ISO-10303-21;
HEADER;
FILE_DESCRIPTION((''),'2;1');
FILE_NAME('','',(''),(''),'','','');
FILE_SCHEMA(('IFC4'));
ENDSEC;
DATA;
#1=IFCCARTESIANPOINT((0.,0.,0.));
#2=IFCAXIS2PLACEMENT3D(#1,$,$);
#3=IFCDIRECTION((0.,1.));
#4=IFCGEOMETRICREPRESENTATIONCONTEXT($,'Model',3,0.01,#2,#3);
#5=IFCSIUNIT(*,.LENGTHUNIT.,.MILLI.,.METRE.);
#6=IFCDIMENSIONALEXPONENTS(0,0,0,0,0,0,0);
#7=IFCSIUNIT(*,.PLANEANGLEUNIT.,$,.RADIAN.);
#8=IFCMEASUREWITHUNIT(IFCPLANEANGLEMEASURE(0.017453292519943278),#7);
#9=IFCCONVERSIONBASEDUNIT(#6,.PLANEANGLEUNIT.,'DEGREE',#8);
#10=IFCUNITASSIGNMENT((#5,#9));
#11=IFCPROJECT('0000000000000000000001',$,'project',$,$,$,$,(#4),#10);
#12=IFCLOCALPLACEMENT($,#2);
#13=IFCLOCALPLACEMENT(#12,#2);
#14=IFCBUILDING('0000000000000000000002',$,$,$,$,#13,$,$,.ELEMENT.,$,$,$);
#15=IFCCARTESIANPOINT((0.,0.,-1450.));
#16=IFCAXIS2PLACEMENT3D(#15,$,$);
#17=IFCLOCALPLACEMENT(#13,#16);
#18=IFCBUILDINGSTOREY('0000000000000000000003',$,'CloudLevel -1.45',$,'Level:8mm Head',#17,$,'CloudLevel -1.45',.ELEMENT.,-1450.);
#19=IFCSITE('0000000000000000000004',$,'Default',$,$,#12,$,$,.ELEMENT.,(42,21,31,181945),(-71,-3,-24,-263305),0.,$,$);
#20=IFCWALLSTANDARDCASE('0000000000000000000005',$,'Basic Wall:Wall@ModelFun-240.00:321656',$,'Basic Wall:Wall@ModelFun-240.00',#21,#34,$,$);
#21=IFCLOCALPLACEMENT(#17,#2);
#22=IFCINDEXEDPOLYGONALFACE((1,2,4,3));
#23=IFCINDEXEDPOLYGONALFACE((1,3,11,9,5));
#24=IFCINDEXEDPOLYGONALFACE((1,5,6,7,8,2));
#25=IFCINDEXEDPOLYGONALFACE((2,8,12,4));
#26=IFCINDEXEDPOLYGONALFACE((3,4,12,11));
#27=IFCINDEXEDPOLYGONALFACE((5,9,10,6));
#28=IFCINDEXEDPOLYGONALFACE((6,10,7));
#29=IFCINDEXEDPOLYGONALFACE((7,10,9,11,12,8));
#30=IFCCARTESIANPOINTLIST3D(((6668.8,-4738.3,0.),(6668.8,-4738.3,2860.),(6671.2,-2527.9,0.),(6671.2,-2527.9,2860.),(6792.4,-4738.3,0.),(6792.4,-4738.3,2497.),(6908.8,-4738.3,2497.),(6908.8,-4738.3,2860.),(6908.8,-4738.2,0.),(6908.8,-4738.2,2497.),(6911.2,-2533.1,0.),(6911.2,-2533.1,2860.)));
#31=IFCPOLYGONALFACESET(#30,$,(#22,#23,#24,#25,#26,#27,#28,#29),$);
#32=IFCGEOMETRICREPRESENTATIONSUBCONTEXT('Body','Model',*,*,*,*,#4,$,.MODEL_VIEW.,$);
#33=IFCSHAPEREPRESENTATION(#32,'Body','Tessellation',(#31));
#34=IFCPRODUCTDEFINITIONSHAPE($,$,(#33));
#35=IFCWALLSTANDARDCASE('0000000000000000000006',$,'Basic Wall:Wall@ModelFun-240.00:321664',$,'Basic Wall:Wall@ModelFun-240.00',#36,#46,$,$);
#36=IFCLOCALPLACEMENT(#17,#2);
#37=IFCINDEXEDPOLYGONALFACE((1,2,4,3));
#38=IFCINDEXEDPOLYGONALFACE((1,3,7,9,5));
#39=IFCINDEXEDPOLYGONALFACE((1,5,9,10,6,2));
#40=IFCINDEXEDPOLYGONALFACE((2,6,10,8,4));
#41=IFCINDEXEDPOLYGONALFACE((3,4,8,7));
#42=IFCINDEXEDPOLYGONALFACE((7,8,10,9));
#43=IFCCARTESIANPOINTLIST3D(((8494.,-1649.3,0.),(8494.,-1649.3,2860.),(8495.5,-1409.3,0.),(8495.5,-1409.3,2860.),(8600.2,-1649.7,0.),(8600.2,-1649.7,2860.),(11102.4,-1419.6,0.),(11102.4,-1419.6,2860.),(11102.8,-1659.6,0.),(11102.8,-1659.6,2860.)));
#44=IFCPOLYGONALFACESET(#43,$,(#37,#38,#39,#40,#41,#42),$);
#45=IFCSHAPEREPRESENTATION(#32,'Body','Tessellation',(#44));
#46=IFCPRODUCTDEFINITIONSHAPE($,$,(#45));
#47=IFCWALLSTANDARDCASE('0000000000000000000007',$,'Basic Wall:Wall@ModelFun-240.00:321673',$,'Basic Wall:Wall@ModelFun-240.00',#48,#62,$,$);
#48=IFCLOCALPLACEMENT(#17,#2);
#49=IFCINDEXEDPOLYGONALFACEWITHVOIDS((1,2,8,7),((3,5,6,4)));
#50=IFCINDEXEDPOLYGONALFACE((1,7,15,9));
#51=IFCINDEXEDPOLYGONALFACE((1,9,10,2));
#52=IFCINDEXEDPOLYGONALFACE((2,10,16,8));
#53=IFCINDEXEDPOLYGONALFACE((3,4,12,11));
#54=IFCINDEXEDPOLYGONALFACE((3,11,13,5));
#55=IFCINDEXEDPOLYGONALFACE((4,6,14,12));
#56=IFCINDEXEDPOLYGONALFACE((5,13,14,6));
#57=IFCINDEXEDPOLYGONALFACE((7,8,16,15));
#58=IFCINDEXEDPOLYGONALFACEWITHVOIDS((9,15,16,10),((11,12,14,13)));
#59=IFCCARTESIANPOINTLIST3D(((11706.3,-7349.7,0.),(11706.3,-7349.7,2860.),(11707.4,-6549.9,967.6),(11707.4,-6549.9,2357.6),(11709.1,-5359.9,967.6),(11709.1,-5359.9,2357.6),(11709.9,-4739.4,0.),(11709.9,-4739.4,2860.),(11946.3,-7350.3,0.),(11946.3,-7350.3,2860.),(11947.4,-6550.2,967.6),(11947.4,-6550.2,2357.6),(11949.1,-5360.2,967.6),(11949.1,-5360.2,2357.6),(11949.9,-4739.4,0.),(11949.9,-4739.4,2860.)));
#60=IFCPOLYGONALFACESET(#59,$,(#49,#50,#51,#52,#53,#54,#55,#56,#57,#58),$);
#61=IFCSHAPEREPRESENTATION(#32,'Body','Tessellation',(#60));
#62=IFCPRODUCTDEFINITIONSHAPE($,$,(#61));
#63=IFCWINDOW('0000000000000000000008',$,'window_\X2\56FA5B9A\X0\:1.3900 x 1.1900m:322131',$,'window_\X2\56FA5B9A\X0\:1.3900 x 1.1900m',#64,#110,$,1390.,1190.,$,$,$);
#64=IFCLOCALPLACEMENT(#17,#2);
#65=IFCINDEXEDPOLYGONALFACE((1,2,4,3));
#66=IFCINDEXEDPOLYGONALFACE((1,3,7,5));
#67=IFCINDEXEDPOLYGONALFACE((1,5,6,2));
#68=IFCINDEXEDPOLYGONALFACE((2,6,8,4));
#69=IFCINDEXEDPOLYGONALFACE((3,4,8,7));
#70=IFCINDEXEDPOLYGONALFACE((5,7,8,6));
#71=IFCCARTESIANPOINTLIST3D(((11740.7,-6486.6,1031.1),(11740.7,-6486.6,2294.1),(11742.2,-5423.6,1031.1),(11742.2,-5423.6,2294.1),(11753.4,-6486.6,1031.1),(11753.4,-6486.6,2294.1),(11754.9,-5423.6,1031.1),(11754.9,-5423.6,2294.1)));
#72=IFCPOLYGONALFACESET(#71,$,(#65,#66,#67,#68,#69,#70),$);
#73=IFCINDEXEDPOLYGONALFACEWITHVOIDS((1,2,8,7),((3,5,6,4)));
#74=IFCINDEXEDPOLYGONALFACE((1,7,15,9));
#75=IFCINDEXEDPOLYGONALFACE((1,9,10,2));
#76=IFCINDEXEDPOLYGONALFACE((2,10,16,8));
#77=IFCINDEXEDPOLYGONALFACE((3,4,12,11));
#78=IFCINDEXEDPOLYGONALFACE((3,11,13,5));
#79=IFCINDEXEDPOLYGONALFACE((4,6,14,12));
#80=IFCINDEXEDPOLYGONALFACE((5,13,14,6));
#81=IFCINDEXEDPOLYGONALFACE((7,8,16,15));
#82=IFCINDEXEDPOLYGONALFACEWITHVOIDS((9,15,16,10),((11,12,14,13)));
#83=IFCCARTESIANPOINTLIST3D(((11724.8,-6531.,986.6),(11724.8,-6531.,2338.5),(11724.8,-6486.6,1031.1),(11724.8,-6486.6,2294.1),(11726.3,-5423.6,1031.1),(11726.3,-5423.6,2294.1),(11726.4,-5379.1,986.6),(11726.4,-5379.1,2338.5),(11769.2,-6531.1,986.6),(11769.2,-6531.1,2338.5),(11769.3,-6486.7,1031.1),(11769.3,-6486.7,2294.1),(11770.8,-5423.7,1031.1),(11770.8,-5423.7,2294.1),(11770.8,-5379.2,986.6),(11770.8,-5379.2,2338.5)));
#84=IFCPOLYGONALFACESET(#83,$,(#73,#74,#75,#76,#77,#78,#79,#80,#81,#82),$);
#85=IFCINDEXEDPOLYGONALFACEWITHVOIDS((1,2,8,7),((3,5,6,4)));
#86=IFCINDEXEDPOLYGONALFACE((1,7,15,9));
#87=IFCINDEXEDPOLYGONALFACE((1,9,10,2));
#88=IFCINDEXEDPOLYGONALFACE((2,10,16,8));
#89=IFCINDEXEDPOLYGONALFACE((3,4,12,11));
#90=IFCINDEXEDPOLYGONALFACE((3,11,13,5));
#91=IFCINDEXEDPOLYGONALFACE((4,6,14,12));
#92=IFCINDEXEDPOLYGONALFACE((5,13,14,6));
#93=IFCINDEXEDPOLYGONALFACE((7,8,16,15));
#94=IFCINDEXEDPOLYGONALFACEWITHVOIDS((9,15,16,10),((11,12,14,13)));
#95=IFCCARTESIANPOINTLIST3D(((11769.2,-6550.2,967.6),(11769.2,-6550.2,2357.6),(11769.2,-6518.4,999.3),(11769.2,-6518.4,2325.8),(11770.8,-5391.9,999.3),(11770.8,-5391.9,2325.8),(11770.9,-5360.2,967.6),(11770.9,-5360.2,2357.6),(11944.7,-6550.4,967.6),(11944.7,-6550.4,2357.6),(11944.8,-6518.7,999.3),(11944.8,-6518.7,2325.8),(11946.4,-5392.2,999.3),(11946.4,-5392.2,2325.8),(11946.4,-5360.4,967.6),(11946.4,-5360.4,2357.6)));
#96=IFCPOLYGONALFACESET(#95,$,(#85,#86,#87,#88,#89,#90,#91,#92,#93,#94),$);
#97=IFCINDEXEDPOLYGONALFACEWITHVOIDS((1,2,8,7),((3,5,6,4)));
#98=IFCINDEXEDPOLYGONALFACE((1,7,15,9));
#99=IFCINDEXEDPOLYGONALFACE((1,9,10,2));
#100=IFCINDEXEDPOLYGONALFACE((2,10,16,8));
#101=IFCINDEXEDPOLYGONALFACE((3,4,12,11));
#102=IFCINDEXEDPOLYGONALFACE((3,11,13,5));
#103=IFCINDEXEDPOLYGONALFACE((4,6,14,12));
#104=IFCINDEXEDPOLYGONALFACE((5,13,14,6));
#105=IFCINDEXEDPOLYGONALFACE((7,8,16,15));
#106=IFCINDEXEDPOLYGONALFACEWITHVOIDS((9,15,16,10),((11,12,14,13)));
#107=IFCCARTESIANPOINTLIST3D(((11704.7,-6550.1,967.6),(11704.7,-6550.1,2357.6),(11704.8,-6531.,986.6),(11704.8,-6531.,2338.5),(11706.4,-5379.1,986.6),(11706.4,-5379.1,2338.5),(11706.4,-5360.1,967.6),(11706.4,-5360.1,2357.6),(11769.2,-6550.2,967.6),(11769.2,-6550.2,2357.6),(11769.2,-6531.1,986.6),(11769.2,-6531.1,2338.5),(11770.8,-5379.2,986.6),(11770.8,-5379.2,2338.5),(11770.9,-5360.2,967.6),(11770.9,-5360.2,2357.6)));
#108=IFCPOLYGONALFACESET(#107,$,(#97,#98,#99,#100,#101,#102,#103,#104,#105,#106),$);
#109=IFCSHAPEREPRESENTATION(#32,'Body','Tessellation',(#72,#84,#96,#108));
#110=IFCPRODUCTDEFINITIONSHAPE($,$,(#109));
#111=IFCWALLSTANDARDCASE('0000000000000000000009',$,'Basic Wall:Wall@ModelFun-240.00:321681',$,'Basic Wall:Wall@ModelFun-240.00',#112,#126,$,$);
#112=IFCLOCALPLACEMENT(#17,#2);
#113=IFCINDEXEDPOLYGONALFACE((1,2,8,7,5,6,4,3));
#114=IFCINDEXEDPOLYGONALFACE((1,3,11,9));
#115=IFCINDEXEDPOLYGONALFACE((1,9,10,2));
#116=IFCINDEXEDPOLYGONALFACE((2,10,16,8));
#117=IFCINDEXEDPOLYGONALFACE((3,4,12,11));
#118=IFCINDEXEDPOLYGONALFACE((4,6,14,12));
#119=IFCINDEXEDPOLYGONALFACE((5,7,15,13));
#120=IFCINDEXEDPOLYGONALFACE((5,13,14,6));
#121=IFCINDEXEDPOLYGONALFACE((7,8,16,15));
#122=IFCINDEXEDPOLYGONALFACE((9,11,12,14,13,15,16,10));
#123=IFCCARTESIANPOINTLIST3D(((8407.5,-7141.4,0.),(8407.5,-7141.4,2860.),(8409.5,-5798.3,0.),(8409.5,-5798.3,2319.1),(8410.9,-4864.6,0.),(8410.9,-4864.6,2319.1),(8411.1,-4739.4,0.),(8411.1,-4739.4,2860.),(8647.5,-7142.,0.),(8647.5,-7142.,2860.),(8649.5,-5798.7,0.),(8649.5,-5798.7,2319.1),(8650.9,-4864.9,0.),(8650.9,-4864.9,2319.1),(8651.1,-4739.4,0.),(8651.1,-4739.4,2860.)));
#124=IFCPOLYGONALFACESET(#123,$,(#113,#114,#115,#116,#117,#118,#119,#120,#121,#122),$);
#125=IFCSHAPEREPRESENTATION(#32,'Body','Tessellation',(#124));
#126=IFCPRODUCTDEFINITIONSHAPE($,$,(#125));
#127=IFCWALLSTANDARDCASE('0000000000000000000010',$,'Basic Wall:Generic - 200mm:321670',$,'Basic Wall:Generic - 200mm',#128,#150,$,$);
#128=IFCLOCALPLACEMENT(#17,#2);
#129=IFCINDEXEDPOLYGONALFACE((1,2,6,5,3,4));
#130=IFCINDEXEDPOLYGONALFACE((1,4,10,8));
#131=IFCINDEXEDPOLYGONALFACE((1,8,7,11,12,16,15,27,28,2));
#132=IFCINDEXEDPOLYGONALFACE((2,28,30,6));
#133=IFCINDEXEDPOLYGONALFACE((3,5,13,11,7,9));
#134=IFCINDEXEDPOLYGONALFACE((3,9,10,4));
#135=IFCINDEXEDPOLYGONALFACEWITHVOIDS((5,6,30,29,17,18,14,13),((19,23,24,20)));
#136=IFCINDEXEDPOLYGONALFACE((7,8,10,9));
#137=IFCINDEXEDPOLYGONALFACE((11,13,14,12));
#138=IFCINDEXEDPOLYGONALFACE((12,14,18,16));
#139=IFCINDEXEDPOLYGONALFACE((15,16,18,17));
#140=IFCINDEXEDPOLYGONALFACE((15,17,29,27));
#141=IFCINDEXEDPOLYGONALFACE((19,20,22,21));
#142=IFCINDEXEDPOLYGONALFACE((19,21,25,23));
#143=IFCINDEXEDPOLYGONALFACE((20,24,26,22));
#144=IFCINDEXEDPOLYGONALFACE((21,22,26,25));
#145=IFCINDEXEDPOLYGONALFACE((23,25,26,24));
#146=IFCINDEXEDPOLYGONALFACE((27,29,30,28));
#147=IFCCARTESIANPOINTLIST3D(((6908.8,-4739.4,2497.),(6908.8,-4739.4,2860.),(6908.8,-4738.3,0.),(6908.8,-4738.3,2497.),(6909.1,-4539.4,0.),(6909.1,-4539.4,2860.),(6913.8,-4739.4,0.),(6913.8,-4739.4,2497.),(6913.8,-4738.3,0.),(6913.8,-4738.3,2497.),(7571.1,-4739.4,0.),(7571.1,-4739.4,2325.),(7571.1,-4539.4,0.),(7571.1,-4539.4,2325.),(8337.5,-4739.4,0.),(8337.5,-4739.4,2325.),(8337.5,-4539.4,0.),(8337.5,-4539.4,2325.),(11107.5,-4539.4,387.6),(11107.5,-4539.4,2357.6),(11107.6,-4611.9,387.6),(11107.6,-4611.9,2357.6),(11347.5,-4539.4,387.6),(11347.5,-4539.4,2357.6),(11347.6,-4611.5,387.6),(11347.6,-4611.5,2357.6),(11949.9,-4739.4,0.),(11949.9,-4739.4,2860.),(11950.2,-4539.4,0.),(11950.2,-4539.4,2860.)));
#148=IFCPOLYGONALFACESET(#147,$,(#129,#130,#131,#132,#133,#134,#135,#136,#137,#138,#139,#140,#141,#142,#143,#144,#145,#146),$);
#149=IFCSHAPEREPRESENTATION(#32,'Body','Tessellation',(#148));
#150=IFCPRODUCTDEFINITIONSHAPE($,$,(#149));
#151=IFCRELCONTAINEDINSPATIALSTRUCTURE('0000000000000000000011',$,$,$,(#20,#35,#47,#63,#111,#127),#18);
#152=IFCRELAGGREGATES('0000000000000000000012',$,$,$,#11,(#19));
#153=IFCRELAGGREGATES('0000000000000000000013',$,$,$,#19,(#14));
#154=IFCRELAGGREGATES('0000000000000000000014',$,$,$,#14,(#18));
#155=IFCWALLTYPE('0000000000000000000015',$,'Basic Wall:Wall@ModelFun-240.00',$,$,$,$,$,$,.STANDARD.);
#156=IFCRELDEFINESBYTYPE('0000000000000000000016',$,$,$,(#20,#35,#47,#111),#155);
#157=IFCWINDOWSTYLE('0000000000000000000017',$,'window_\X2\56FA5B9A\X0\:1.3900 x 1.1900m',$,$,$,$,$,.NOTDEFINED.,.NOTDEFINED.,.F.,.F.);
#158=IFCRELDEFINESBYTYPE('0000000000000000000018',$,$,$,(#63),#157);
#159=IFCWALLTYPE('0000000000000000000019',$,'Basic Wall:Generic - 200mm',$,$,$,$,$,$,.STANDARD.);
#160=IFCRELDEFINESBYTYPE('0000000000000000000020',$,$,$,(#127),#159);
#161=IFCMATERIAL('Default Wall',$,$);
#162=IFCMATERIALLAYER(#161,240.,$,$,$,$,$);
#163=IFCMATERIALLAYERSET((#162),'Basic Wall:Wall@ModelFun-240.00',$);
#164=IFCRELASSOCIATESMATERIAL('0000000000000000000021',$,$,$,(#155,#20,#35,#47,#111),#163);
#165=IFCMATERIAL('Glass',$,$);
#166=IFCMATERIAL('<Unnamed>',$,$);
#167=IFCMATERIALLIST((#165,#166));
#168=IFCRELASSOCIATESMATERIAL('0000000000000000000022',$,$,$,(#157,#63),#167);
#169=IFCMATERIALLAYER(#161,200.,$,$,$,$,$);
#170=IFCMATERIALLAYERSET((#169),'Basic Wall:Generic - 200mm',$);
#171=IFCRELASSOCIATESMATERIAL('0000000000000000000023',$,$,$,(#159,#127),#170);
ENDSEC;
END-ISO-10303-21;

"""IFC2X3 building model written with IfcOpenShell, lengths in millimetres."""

from ifc_helpers import new_model, entity, si_unit, converted_unit, direction, frame, frame_2d, origin, place, context, subcontext, project, spatial, polyline, rectangle, outline, extrude, source, transform, mapped, material, material_list, layer, layer_set, layer_usage, type_object, type_shapes, element, fill, save


model = new_model("IFC2X3")

# Units and contexts
model_context = context("Model", 3, precision=0.01, world=origin(), true_north=direction((0.0, 1.0)))
body_context = subcontext(model_context, "Body", "Model", "MODEL_VIEW")
ifc_project = project(units=[si_unit("LENGTHUNIT", "METRE", prefix="MILLI"), converted_unit("PLANEANGLEUNIT", "DEGREE", entity("IfcPlaneAngleMeasure", 0.017453292519943278), si_unit("PLANEANGLEUNIT", "RADIAN"), dimensions=[0, 0, 0, 0, 0, 0, 0])], contexts=[model_context])

# Site, building, storey
site_placement = place(None, origin())
site = spatial("IfcSite", under=ifc_project, at=site_placement, Name="Default", CompositionType="ELEMENT", RefLatitude=(42, 21, 31, 181945), RefLongitude=(-71, -3, -24, -263305), RefElevation=0.0)
building_placement = place(site_placement, origin())
building = spatial("IfcBuilding", under=site, at=building_placement, CompositionType="ELEMENT")
storey_placement = place(building_placement, frame((0.0, 0.0, -1450.0)))
storey = spatial("IfcBuildingStorey", under=building, at=storey_placement, Name="CloudLevel -1.45", ObjectType="Level:8mm Head", LongName="CloudLevel -1.45", CompositionType="ELEMENT", Elevation=-1450.0)

# Shared definitions
ifc_material_1 = material(Name="Default Wall")
ifc_layer_1 = layer(ifc_material_1, 240.0)
ifc_layer_set_1 = layer_set([ifc_layer_1], Name="Basic Wall:Wall@ModelFun-240.00")
ifc_layer_usage_1 = layer_usage(ifc_layer_set_1, "AXIS2", "NEGATIVE", 120.0)
wall_type_1 = type_object("IfcWallType", Name="Basic Wall:Wall@ModelFun-240.00", PredefinedType="STANDARD", material=ifc_layer_set_1)
ifc_material_2 = material(Name="Glass")
ifc_material_3 = material(Name="<Unnamed>")
ifc_material_list = material_list([ifc_material_2, ifc_material_3])

# Wall, opening
wall_1_placement = place(storey_placement, frame((6791.2, -2528.0, 0.0), z_axis=(0.0, 0.0, 1.0), x_axis=(-0.001074, -0.999999, 0.0)))
wall_1 = element("IfcWallStandardCase", 1, at=wall_1_placement, inside=storey, type_object=wall_type_1, material=ifc_layer_usage_1, Name="Basic Wall:Wall@ModelFun-240.00:321656", ObjectType="Basic Wall:Wall@ModelFun-240.00", context=body_context, shape_type="SweptSolid", body=[
    extrude(outline(polyline([(0.0, -120.0), (2210.4, -120.0), (2210.1, 120.0), (2011.2, 120.0), (5.0, 120.0), (0.0, -120.0)])), origin(), (0.0, 0.0, 1.0), 2860.0),
])
opening_1_placement = place(wall_1_placement, frame((0.0, 0.0, 0.0), z_axis=(0.0, 0.0, 1.0), x_axis=(0.999999, 0.001074, 0.0)))
element("IfcOpeningElement", 2, at=opening_1_placement, cuts=wall_1, ObjectType="Opening", context=body_context, shape_type="SweptSolid", body=[
    extrude(rectangle(XDim=2497.0, YDim=1048.4, at=frame_2d((0.0, 0.0), x_axis=(0.0, 1.0))), frame((2736.2, -1608.5, 1248.5), z_axis=(-0.001074, 0.999999, 0.0), x_axis=(-0.999999, -0.001074, 0.0)), (0.0, 0.0, 1.0), 3048.0),
])

# Wall
wall_2_placement = place(storey_placement, frame((11103.3, -1539.6, 0.0), z_axis=(0.0, 0.0, 1.0), x_axis=(-0.999992, 0.003928, 0.0)))
element("IfcWallStandardCase", 3, at=wall_2_placement, inside=storey, type_object=wall_type_1, material=ifc_layer_usage_1, Name="Basic Wall:Wall@ModelFun-240.00:321664", ObjectType="Basic Wall:Wall@ModelFun-240.00", context=body_context, shape_type="SweptSolid", body=[
    extrude(outline(polyline([(2608.3, -120.0), (2608.8, 120.0), (2502.6, 120.0), (0.0, 120.0), (1.3, -120.0), (2608.3, -120.0)])), origin(), (0.0, 0.0, 1.0), 2860.0),
])

# Wall, opening, window
wall_3_placement = place(storey_placement, frame((11829.9, -4739.3, 0.0), z_axis=(0.0, 0.0, 1.0), x_axis=(-0.001406, -0.999999, 0.0)))
wall_3 = element("IfcWallStandardCase", 4, at=wall_3_placement, inside=storey, type_object=wall_type_1, material=ifc_layer_usage_1, Name="Basic Wall:Wall@ModelFun-240.00:321673", ObjectType="Basic Wall:Wall@ModelFun-240.00", context=body_context, shape_type="SweptSolid", body=[
    extrude(outline(polyline([(2610.6, -120.0), (2610.6, -117.9), (2610.9, 120.0), (0.0, 120.0), (0.3, -120.0), (2410.6, -120.0), (2610.6, -120.0)])), origin(), (0.0, 0.0, 1.0), 2860.0),
])
opening_2_placement = place(wall_3_placement, frame((1810.8, 120.0, 967.6)))
opening_2 = element("IfcOpeningElement", 5, at=opening_2_placement, cuts=wall_3, ObjectType="Opening", context=body_context, shape_type="SweptSolid", body=[
    extrude(rectangle(XDim=1390.0, YDim=1190.0, at=frame_2d((695.0, 595.0), x_axis=(-1.0, 0.0))), frame((0.0, 0.0, 0.0), z_axis=(0.0, -1.0, 0.0), x_axis=(0.0, 0.0, 1.0)), (0.0, 0.0, 1.0), 240.0),
])
window_style_1 = type_object("IfcWindowStyle", Name="window_固定:1.3900 x 1.1900m", ConstructionType="NOTDEFINED", OperationType="NOTDEFINED", ParameterTakesPrecedence=False, Sizeable=False, material=ifc_material_list)
shared_shape_1 = source(origin(), body_context, "Body", "SweptSolid", [
    extrude(rectangle(XDim=1063.0, YDim=12.7, at=frame_2d((0.0, 0.0), x_axis=(1.0, 0.0))), frame((671.2, 197.8, 63.5)), (0.0, 0.0, 1.0), 1263.0),
    extrude(outline(polyline([(-575.9, -675.9), (575.9, -675.9), (575.9, 675.9), (-575.9, 675.9), (-575.9, -675.9)]), holes=[polyline([(-531.5, -631.5), (-531.5, 631.5), (531.5, 631.5), (531.5, -631.5), (-531.5, -631.5)])]), frame((671.2, 220.0, 695.0), z_axis=(0.0, -1.0, 0.0), x_axis=(-1.0, 0.0, 0.0)), (0.0, 0.0, 1.0), 44.4),
    extrude(outline(polyline([(-595.0, -695.0), (595.0, -695.0), (595.0, 695.0), (-595.0, 695.0), (-595.0, -695.0)]), holes=[polyline([(-563.2, -663.2), (-563.2, 663.2), (563.2, 663.2), (563.2, -663.2), (-563.2, -663.2)])]), frame((671.2, 175.5, 695.0), z_axis=(0.0, -1.0, 0.0), x_axis=(-1.0, 0.0, 0.0)), (0.0, 0.0, 1.0), 175.5),
    extrude(outline(polyline([(-695.0, -595.0), (695.0, -595.0), (695.0, 595.0), (-695.0, 595.0), (-695.0, -595.0)]), holes=[polyline([(-675.9, -575.9), (-675.9, 575.9), (675.9, 575.9), (675.9, -575.9), (-675.9, -575.9)])]), frame((671.2, 240.0, 695.0), z_axis=(0.0, -1.0, 0.0), x_axis=(0.0, 0.0, -1.0)), (0.0, 0.0, 1.0), 64.4),
])
type_shapes(window_style_1, [shared_shape_1])
window_1_placement = place(opening_2_placement, frame((76.4, -2.7, 0.0), z_axis=(0.0, 0.0, 1.0), x_axis=(-1.0, 0.0, 0.0)))
window_1 = element("IfcWindow", 6, at=window_1_placement, inside=storey, type_object=window_style_1, material=ifc_material_list, Name="window_固定:1.3900 x 1.1900m:322131", ObjectType="window_固定:1.3900 x 1.1900m", OverallHeight=1390.0, OverallWidth=1190.0, context=body_context, shape_type="MappedRepresentation", body=[
    mapped(shared_shape_1, transform((0.0, 0.0, 0.0), scale=1.0)),
])
fill(opening_2, window_1)

# Wall, opening
wall_4_placement = place(storey_placement, frame((8531.1, -4739.2, 0.0), z_axis=(0.0, 0.0, 1.0), x_axis=(-0.001482, -0.999999, 0.0)))
wall_4 = element("IfcWallStandardCase", 7, at=wall_4_placement, inside=storey, type_object=wall_type_1, material=ifc_layer_usage_1, Name="Basic Wall:Wall@ModelFun-240.00:321681", ObjectType="Basic Wall:Wall@ModelFun-240.00", context=body_context, shape_type="SweptSolid", body=[
    extrude(outline(polyline([(0.4, -120.0), (1048.8, -120.0), (1168.8, -120.0), (2402.3, -120.0), (2402.6, 120.0), (0.0, 120.0), (0.4, -120.0)])), origin(), (0.0, 0.0, 1.0), 2860.0),
])
opening_3_placement = place(wall_4_placement, frame((125.5, -120.0, 0.0)))
element("IfcOpeningElement", 8, at=opening_3_placement, cuts=wall_4, ObjectType="Opening", context=body_context, shape_type="SweptSolid", body=[
    extrude(rectangle(XDim=933.8, YDim=2319.1, at=frame_2d((1159.5, 466.9), x_axis=(0.0, 1.0))), frame((0.0, 0.0, 0.0), z_axis=(0.0, 1.0, 0.0), x_axis=(0.0, 0.0, 1.0)), (0.0, 0.0, 1.0), 240.0),
])

# Wall, openings
ifc_layer_2 = layer(ifc_material_1, 200.0)
ifc_layer_set_2 = layer_set([ifc_layer_2], Name="Basic Wall:Generic - 200mm")
ifc_layer_usage_2 = layer_usage(ifc_layer_set_2, "AXIS2", "NEGATIVE", 100.0)
wall_type_2 = type_object("IfcWallType", Name="Basic Wall:Generic - 200mm", PredefinedType="STANDARD", material=ifc_layer_set_2)
wall_5_placement = place(storey_placement, frame((6908.8, -4639.4, 0.0)))
wall_5 = element("IfcWallStandardCase", 9, at=wall_5_placement, inside=storey, type_object=wall_type_2, material=ifc_layer_usage_2, Name="Basic Wall:Generic - 200mm:321670", ObjectType="Basic Wall:Generic - 200mm", context=body_context, shape_type="SweptSolid", body=[
    extrude(outline(polyline([(0.0, -100.0), (5.0, -100.0), (1502.2, -100.0), (1742.2, -100.0), (4801.1, -100.0), (5041.1, -100.0), (5041.4, 100.0), (4438.7, 100.0), (4198.7, 100.0), (1712.7, 100.0), (1502.7, 100.0), (0.2, 100.0), (0.0, -100.0)])), origin(), (0.0, 0.0, 1.0), 2860.0),
])
opening_4_placement = place(wall_5_placement, origin())
element("IfcOpeningElement", 10, at=opening_4_placement, cuts=wall_5, ObjectType="Opening", context=body_context, shape_type="SweptSolid", body=[
    extrude(rectangle(XDim=2497.0, YDim=210.0, at=frame_2d((0.0, 0.0), x_axis=(0.0, 1.0))), frame((-100.0, -1147.3, 1248.5), z_axis=(0.0, 1.0, 0.0), x_axis=(-1.0, 0.0, 0.0)), (0.0, 0.0, 1.0), 1048.4),
])
opening_5_placement = place(wall_5_placement, origin())
element("IfcOpeningElement", 11, at=opening_5_placement, cuts=wall_5, ObjectType="Opening", context=body_context, shape_type="SweptSolid", body=[
    extrude(rectangle(XDim=1970.0, YDim=240.0, at=frame_2d((0.0, 0.0), x_axis=(0.0, 1.0))), frame((4318.8, 27.7, 1372.6), z_axis=(-0.001635, 0.999999, 0.0), x_axis=(-0.999999, -0.001635, 0.0)), (0.0, 0.0, 1.0), 2860.0),
])
opening_6_placement = place(wall_5_placement, frame((662.2, -100.0, 0.0)))
element("IfcOpeningElement", 12, at=opening_6_placement, cuts=wall_5, ObjectType="Opening", context=body_context, shape_type="SweptSolid", body=[
    extrude(rectangle(XDim=766.4, YDim=2325.0, at=frame_2d((1162.5, 383.2), x_axis=(0.0, 1.0))), frame((0.0, 0.0, 0.0), z_axis=(0.0, 1.0, 0.0), x_axis=(0.0, 0.0, 1.0)), (0.0, 0.0, 1.0), 200.0),
])

save(model, "model.ifc")
